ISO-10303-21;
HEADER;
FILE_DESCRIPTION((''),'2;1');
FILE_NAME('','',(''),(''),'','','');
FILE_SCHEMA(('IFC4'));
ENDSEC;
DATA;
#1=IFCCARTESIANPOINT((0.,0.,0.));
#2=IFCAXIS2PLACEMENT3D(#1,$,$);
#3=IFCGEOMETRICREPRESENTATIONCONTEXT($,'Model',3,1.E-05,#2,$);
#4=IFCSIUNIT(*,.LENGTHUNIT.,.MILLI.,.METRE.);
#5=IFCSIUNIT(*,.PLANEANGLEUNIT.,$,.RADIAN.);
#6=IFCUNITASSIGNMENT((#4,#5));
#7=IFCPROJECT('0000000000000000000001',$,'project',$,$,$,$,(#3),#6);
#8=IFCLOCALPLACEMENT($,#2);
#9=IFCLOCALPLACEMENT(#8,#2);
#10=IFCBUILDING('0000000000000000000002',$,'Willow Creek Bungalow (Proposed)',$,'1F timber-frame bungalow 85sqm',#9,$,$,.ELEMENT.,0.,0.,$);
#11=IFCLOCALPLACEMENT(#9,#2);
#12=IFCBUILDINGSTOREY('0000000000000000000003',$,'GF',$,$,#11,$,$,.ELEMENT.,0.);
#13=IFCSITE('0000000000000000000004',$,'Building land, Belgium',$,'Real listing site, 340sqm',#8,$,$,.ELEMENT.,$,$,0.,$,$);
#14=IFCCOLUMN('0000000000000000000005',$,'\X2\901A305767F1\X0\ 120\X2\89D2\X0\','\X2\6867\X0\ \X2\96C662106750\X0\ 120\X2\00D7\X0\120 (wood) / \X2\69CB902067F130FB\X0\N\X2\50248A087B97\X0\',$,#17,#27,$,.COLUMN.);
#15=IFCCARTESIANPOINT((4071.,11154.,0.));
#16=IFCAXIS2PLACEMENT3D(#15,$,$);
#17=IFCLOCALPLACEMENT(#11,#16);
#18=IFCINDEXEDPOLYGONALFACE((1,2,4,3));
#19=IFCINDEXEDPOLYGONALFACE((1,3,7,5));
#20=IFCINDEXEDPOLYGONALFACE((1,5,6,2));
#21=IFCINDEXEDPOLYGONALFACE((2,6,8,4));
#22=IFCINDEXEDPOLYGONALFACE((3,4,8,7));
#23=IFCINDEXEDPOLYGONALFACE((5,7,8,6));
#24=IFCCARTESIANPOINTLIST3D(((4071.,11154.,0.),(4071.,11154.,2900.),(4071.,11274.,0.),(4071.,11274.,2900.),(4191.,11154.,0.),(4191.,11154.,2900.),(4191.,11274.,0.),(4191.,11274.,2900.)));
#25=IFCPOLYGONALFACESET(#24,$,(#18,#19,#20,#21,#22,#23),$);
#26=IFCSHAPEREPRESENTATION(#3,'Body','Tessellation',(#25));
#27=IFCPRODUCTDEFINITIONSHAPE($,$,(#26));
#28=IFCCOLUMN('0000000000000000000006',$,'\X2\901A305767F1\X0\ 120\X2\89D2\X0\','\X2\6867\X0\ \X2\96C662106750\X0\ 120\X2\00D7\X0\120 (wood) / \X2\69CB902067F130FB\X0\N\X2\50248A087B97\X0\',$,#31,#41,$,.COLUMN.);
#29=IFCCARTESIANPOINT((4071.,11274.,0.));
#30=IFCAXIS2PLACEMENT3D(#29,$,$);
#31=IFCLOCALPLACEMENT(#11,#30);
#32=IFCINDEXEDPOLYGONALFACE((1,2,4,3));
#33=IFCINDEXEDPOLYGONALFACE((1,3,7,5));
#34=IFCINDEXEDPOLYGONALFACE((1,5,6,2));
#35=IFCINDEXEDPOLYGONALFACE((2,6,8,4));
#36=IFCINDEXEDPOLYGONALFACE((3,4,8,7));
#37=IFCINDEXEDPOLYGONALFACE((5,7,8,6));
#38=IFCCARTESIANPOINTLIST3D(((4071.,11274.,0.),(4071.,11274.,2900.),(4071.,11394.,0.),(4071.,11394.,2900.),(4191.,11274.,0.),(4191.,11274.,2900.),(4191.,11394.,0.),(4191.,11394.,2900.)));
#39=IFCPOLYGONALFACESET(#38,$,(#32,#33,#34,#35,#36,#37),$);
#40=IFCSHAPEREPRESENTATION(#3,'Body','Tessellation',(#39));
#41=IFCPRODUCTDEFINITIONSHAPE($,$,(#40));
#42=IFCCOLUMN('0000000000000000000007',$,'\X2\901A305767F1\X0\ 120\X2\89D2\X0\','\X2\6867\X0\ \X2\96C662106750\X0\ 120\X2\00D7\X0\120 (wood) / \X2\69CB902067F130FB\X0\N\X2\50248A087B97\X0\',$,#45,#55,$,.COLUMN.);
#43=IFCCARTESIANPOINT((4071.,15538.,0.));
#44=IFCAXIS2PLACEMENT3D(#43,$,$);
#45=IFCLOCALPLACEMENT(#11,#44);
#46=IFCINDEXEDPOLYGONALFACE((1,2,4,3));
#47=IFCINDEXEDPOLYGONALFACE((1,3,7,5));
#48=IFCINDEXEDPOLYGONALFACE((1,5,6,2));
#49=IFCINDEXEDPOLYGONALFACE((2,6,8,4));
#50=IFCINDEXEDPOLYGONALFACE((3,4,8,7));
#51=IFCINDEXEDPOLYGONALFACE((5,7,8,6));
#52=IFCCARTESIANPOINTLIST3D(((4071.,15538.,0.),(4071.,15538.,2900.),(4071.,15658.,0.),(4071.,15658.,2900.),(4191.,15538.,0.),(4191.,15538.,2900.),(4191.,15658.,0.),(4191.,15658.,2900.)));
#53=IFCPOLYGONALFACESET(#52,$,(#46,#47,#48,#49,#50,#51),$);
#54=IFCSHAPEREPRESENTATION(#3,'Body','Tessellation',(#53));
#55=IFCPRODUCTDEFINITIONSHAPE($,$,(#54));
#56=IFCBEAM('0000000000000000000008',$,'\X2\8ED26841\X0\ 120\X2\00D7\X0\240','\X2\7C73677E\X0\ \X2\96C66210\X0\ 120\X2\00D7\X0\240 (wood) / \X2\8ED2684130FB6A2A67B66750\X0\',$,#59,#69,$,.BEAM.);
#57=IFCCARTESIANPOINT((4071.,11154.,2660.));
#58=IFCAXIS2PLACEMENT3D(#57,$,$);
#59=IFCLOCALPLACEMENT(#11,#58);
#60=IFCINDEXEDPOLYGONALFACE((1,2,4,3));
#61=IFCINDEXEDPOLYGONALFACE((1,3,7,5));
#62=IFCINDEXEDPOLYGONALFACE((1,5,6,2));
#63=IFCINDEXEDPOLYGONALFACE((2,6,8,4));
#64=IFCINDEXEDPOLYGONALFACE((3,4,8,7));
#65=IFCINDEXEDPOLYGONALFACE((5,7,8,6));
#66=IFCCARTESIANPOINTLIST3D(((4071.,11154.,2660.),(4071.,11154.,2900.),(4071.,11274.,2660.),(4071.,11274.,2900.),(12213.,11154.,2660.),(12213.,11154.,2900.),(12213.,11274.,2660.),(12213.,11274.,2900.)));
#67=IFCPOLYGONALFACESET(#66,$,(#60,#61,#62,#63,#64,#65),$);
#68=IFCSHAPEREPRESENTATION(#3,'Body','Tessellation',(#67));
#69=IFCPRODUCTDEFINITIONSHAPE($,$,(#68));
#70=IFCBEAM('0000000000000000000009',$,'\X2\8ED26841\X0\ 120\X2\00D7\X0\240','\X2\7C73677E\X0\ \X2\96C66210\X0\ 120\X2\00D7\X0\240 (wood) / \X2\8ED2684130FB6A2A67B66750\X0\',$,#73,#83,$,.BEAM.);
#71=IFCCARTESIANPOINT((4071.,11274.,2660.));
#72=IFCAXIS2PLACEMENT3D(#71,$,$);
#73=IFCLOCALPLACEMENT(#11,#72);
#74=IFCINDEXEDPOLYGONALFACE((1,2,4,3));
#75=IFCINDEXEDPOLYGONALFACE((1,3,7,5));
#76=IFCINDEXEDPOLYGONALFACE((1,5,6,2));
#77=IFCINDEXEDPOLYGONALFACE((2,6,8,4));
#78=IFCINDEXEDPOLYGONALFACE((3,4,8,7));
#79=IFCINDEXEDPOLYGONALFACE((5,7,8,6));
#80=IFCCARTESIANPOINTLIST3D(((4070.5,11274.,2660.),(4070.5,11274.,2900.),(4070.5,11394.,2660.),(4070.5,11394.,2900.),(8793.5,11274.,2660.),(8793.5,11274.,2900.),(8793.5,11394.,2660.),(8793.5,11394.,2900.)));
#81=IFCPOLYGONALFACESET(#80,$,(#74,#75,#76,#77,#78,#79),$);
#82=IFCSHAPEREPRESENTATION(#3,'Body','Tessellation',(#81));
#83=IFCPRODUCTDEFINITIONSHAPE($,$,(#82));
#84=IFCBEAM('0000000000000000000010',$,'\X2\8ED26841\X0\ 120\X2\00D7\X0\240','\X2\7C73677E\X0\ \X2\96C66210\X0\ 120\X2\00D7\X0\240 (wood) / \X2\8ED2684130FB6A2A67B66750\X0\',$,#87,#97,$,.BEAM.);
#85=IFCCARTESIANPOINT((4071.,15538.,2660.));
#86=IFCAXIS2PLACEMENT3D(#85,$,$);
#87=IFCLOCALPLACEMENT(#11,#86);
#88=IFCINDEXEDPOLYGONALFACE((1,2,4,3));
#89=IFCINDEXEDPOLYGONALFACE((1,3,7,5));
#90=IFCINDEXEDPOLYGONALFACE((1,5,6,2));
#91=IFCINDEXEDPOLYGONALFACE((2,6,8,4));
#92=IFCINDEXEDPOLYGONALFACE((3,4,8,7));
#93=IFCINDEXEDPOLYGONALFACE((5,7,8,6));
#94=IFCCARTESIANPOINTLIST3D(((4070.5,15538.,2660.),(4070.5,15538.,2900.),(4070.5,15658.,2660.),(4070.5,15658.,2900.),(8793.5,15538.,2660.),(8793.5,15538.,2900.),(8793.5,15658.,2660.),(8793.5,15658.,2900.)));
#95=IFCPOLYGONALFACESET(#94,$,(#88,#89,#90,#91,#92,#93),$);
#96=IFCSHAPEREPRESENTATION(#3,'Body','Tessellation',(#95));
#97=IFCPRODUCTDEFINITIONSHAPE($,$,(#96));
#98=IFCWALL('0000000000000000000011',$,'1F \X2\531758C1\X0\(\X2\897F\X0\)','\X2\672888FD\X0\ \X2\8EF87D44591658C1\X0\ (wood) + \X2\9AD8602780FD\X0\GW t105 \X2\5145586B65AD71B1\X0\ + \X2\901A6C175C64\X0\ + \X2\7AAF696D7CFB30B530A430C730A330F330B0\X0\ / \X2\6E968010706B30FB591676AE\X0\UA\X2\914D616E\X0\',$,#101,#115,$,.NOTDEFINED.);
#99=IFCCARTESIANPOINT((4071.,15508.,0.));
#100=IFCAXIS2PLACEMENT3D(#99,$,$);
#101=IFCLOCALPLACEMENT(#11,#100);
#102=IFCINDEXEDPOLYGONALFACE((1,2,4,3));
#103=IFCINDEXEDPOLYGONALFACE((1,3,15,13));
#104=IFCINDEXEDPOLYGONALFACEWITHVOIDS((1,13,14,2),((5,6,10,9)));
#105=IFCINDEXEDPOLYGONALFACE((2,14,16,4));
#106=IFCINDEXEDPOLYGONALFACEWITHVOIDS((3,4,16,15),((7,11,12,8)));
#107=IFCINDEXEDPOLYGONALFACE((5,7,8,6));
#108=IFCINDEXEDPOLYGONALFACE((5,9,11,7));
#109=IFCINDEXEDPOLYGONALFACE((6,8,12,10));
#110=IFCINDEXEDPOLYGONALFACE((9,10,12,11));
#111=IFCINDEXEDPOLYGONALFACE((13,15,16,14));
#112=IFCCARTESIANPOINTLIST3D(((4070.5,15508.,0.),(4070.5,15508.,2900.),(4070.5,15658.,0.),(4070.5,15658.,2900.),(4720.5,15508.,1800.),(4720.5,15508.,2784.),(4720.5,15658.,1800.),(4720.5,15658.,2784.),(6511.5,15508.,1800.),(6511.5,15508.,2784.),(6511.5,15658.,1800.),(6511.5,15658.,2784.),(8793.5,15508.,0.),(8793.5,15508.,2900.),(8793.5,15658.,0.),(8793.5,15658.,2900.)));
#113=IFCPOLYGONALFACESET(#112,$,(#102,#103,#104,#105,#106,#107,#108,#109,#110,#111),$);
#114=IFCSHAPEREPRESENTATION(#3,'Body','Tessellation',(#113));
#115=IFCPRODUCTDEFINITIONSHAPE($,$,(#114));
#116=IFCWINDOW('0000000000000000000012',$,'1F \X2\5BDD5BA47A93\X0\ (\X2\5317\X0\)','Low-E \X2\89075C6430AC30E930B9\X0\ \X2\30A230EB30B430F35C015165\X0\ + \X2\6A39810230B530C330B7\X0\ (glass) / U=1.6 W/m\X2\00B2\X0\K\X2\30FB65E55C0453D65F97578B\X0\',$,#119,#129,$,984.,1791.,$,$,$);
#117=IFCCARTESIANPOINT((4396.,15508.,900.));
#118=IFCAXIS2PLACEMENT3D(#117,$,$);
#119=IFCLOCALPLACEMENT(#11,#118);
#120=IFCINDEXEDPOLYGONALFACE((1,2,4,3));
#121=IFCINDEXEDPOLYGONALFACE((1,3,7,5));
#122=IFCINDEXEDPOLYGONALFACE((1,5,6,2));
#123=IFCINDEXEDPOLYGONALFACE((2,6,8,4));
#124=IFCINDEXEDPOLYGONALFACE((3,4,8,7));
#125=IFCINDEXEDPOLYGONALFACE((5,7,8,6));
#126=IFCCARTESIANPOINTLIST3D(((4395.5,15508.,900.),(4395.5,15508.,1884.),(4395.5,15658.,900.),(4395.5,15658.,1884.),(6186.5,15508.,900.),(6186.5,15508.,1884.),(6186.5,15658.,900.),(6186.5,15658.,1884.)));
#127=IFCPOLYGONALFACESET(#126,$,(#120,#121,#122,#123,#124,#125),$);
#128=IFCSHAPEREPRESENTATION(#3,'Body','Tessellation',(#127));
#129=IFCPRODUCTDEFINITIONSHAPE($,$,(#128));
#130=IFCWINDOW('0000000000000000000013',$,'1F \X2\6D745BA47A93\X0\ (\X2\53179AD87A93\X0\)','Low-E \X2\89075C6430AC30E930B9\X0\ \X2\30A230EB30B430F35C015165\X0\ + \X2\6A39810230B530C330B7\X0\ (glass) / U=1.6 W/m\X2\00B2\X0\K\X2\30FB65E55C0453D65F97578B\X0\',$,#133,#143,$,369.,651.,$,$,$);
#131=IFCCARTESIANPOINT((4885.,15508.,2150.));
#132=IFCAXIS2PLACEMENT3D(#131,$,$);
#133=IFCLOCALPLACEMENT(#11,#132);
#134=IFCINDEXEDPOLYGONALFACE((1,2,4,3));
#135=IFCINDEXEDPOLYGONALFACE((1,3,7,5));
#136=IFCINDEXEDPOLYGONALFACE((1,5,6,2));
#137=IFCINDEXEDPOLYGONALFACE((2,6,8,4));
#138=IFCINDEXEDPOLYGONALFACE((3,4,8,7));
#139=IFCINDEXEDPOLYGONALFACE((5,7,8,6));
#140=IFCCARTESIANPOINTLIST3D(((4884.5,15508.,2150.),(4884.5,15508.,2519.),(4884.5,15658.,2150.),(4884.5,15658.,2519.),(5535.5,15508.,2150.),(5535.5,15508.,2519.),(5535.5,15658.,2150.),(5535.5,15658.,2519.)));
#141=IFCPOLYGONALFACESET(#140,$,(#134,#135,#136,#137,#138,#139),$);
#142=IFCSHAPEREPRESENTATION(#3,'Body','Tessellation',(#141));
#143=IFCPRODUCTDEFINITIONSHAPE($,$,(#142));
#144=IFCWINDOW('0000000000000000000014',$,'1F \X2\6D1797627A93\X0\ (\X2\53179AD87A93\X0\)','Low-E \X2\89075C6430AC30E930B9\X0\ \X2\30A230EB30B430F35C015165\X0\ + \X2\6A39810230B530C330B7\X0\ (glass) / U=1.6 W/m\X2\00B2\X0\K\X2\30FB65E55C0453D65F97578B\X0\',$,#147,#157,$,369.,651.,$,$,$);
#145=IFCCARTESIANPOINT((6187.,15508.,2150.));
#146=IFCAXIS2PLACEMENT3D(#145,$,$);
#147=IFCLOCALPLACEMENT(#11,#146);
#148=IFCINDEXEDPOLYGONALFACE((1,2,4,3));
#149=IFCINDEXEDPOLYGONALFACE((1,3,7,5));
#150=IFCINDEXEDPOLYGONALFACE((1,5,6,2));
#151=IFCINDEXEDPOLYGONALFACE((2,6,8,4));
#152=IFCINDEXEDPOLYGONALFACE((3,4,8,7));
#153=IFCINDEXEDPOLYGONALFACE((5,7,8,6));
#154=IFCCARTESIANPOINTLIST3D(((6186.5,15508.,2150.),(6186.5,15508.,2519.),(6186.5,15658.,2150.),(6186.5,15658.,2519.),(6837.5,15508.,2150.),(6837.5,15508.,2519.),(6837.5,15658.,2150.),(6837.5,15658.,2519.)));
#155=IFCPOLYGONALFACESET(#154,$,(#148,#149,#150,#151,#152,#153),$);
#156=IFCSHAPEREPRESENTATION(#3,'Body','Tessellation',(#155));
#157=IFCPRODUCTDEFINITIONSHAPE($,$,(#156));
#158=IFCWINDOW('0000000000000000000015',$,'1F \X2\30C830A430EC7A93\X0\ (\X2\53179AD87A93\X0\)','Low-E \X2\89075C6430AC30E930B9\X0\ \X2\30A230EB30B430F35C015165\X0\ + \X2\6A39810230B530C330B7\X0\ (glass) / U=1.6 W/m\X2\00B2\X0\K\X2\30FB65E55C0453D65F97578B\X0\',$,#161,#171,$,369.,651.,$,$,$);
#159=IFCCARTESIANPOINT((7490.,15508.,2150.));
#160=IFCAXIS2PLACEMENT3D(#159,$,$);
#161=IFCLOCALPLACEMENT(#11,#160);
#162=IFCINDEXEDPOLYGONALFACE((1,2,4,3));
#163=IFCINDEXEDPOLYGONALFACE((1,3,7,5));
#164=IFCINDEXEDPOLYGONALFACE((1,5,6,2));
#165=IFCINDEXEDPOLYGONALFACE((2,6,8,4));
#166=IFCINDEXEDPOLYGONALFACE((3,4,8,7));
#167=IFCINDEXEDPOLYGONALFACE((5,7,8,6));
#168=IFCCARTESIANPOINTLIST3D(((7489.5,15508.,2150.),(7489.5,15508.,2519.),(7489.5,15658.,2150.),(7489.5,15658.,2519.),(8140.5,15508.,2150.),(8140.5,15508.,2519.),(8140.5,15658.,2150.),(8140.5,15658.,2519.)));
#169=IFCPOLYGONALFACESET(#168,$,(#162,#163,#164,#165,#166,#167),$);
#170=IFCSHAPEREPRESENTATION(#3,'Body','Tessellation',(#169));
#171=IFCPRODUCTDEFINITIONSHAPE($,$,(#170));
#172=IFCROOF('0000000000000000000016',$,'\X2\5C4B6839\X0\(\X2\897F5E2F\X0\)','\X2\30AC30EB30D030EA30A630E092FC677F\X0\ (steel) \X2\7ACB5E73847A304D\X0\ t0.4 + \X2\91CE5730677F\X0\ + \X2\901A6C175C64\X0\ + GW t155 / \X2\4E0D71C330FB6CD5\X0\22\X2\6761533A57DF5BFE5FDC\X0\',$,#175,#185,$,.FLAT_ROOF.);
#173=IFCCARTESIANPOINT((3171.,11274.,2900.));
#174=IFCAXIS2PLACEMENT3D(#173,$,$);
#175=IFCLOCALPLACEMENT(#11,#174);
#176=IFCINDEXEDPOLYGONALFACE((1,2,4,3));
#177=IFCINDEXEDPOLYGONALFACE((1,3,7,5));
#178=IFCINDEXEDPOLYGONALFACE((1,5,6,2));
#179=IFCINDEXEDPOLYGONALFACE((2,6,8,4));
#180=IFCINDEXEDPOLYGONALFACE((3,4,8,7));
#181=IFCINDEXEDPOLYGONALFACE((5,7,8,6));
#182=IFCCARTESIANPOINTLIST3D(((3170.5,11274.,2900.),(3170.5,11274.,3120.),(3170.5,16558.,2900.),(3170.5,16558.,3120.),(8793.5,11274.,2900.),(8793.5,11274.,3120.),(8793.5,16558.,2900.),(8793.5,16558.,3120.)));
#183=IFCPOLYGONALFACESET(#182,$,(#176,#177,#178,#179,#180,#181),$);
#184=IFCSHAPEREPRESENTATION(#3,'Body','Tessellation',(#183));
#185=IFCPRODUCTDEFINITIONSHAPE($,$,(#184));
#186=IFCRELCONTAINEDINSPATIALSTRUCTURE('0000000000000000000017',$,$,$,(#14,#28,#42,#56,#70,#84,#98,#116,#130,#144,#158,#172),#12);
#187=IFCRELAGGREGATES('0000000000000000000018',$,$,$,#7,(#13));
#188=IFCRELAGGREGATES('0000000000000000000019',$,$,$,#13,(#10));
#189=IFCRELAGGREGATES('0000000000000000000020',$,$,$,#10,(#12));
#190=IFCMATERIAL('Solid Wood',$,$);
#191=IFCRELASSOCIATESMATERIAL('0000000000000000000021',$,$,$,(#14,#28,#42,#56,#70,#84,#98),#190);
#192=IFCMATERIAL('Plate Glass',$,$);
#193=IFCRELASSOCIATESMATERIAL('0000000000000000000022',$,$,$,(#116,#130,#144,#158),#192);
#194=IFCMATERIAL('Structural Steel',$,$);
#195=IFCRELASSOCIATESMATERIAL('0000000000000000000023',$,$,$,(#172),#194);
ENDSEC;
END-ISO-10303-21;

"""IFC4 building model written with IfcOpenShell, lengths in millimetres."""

from ifc_helpers import new_model, si_unit, frame, frame_2d, origin, place, context, project, spatial, rectangle, extrude, material, element, fill, save


model = new_model("IFC4")

# Units and contexts
model_context = context("Model", 3, precision=1e-05, world=origin())
ifc_project = project(units=[si_unit("LENGTHUNIT", "METRE", prefix="MILLI"), si_unit("PLANEANGLEUNIT", "RADIAN")], contexts=[model_context])

# Site, building, storey
site_placement = place(None, origin())
site = spatial("IfcSite", under=ifc_project, at=site_placement, Name="Building land, Belgium", ObjectType="Real listing site, 340sqm", CompositionType="ELEMENT", RefElevation=0.0)
building_placement = place(site_placement, origin())
building = spatial("IfcBuilding", under=site, at=building_placement, Name="Willow Creek Bungalow (Proposed)", ObjectType="1F timber-frame bungalow 85sqm", CompositionType="ELEMENT", ElevationOfRefHeight=0.0, ElevationOfTerrain=0.0)
storey_placement = place(building_placement, origin())
storey = spatial("IfcBuildingStorey", under=building, at=storey_placement, Name="GF", CompositionType="ELEMENT", Elevation=0.0)

# Columns
ifc_material_1 = material(Name="Solid Wood")
column_1_placement = place(storey_placement, frame((4071.0, 11154.0, 0.0)))
element("IfcColumn", 1, at=column_1_placement, inside=storey, material=ifc_material_1, Name="通し柱 120角", Description="桧 集成材 120×120 (wood) / 構造柱・N値計算", PredefinedType="COLUMN", context=model_context, shape_type="SweptSolid", body=[
    extrude(rectangle(XDim=120.0, YDim=120.0, at=frame_2d((60.0, 60.0))), frame((4071.0, 11154.0, 0.0)), (0.0, 0.0, 1.0), 2900.0),
])
column_2_placement = place(storey_placement, frame((4071.0, 11274.0, 0.0)))
element("IfcColumn", 2, at=column_2_placement, inside=storey, material=ifc_material_1, Name="通し柱 120角", Description="桧 集成材 120×120 (wood) / 構造柱・N値計算", PredefinedType="COLUMN", context=model_context, shape_type="SweptSolid", body=[
    extrude(rectangle(XDim=120.0, YDim=120.0, at=frame_2d((60.0, 60.0))), frame((4071.0, 11274.0, 0.0)), (0.0, 0.0, 1.0), 2900.0),
])
column_3_placement = place(storey_placement, frame((4071.0, 15538.0, 0.0)))
element("IfcColumn", 3, at=column_3_placement, inside=storey, material=ifc_material_1, Name="通し柱 120角", Description="桧 集成材 120×120 (wood) / 構造柱・N値計算", PredefinedType="COLUMN", context=model_context, shape_type="SweptSolid", body=[
    extrude(rectangle(XDim=120.0, YDim=120.0, at=frame_2d((60.0, 60.0))), frame((4071.0, 15538.0, 0.0)), (0.0, 0.0, 1.0), 2900.0),
])

# Beams
beam_1_placement = place(storey_placement, frame((4071.0, 11154.0, 2660.0)))
element("IfcBeam", 4, at=beam_1_placement, inside=storey, material=ifc_material_1, Name="軒桁 120×240", Description="米松 集成 120×240 (wood) / 軒桁・横架材", PredefinedType="BEAM", context=model_context, shape_type="SweptSolid", body=[
    extrude(rectangle(XDim=8142.0, YDim=120.0, at=frame_2d((4071.0, 60.0))), frame((4071.0, 11154.0, 2660.0)), (0.0, 0.0, 1.0), 240.0),
])
beam_2_placement = place(storey_placement, frame((4071.0, 11274.0, 2660.0)))
element("IfcBeam", 5, at=beam_2_placement, inside=storey, material=ifc_material_1, Name="軒桁 120×240", Description="米松 集成 120×240 (wood) / 軒桁・横架材", PredefinedType="BEAM", context=model_context, shape_type="SweptSolid", body=[
    extrude(rectangle(XDim=4723.0, YDim=120.0, at=frame_2d((2361.0, 60.0))), frame((4071.0, 11274.0, 2660.0)), (0.0, 0.0, 1.0), 240.0),
])
beam_3_placement = place(storey_placement, frame((4071.0, 15538.0, 2660.0)))
element("IfcBeam", 6, at=beam_3_placement, inside=storey, material=ifc_material_1, Name="軒桁 120×240", Description="米松 集成 120×240 (wood) / 軒桁・横架材", PredefinedType="BEAM", context=model_context, shape_type="SweptSolid", body=[
    extrude(rectangle(XDim=4723.0, YDim=120.0, at=frame_2d((2361.0, 60.0))), frame((4071.0, 15538.0, 2660.0)), (0.0, 0.0, 1.0), 240.0),
])

# Wall, openings, windows
wall_1_placement = place(storey_placement, frame((4071.0, 15508.0, 0.0)))
wall_1 = element("IfcWall", 7, at=wall_1_placement, inside=storey, material=ifc_material_1, Name="1F 北壁(西)", Description="木製 軸組外壁 (wood) + 高性能GW t105 充填断熱 + 通気層 + 窯業系サイディング / 準耐火・外皮UA配慮", PredefinedType="NOTDEFINED", context=model_context, shape_type="SweptSolid", body=[
    extrude(rectangle(XDim=4723.0, YDim=150.0, at=frame_2d((2361.0, 75.0))), frame((4071.0, 15508.0, 0.0)), (0.0, 0.0, 1.0), 2900.0),
])
opening_1_placement = place(storey_placement, frame((4396.0, 15508.0, 900.0)))
opening_1 = element("IfcOpeningElement", 8, at=opening_1_placement, cuts=wall_1, PredefinedType="NOTDEFINED", context=model_context, shape_type="SweptSolid", body=[
    extrude(rectangle(XDim=1791.0, YDim=150.0, at=frame_2d((895.0, 75.0))), frame((4396.0, 15508.0, 900.0)), (0.0, 0.0, 1.0), 984.0),
])
opening_2_placement = place(storey_placement, frame((4885.0, 15508.0, 2150.0)))
opening_2 = element("IfcOpeningElement", 9, at=opening_2_placement, cuts=wall_1, PredefinedType="NOTDEFINED", context=model_context, shape_type="SweptSolid", body=[
    extrude(rectangle(XDim=651.0, YDim=150.0, at=frame_2d((325.0, 75.0))), frame((4885.0, 15508.0, 2150.0)), (0.0, 0.0, 1.0), 369.0),
])
opening_3_placement = place(storey_placement, frame((6187.0, 15508.0, 2150.0)))
opening_3 = element("IfcOpeningElement", 10, at=opening_3_placement, cuts=wall_1, PredefinedType="NOTDEFINED", context=model_context, shape_type="SweptSolid", body=[
    extrude(rectangle(XDim=651.0, YDim=150.0, at=frame_2d((325.0, 75.0))), frame((6187.0, 15508.0, 2150.0)), (0.0, 0.0, 1.0), 369.0),
])
opening_4_placement = place(storey_placement, frame((7490.0, 15508.0, 2150.0)))
opening_4 = element("IfcOpeningElement", 11, at=opening_4_placement, cuts=wall_1, PredefinedType="NOTDEFINED", context=model_context, shape_type="SweptSolid", body=[
    extrude(rectangle(XDim=651.0, YDim=150.0, at=frame_2d((325.0, 75.0))), frame((7490.0, 15508.0, 2150.0)), (0.0, 0.0, 1.0), 369.0),
])
ifc_material_2 = material(Name="Plate Glass")
window_1_placement = place(storey_placement, frame((4396.0, 15508.0, 900.0)))
window_1 = element("IfcWindow", 12, at=window_1_placement, inside=storey, material=ifc_material_2, Name="1F 寝室窓 (北)", Description="Low-E 複層ガラス アルゴン封入 + 樹脂サッシ (glass) / U=1.6 W/m²K・日射取得型", OverallHeight=984.0, OverallWidth=1791.0, context=model_context, shape_type="SweptSolid", body=[
    extrude(rectangle(XDim=1791.0, YDim=150.0, at=frame_2d((895.0, 75.0))), frame((4396.0, 15508.0, 900.0)), (0.0, 0.0, 1.0), 984.0),
])
fill(opening_1, window_1)
window_2_placement = place(storey_placement, frame((4885.0, 15508.0, 2150.0)))
window_2 = element("IfcWindow", 13, at=window_2_placement, inside=storey, material=ifc_material_2, Name="1F 浴室窓 (北高窓)", Description="Low-E 複層ガラス アルゴン封入 + 樹脂サッシ (glass) / U=1.6 W/m²K・日射取得型", OverallHeight=369.0, OverallWidth=651.0, context=model_context, shape_type="SweptSolid", body=[
    extrude(rectangle(XDim=651.0, YDim=150.0, at=frame_2d((325.0, 75.0))), frame((4885.0, 15508.0, 2150.0)), (0.0, 0.0, 1.0), 369.0),
])
fill(opening_2, window_2)
window_3_placement = place(storey_placement, frame((6187.0, 15508.0, 2150.0)))
window_3 = element("IfcWindow", 14, at=window_3_placement, inside=storey, material=ifc_material_2, Name="1F 洗面窓 (北高窓)", Description="Low-E 複層ガラス アルゴン封入 + 樹脂サッシ (glass) / U=1.6 W/m²K・日射取得型", OverallHeight=369.0, OverallWidth=651.0, context=model_context, shape_type="SweptSolid", body=[
    extrude(rectangle(XDim=651.0, YDim=150.0, at=frame_2d((325.0, 75.0))), frame((6187.0, 15508.0, 2150.0)), (0.0, 0.0, 1.0), 369.0),
])
fill(opening_3, window_3)
window_4_placement = place(storey_placement, frame((7490.0, 15508.0, 2150.0)))
window_4 = element("IfcWindow", 15, at=window_4_placement, inside=storey, material=ifc_material_2, Name="1F トイレ窓 (北高窓)", Description="Low-E 複層ガラス アルゴン封入 + 樹脂サッシ (glass) / U=1.6 W/m²K・日射取得型", OverallHeight=369.0, OverallWidth=651.0, context=model_context, shape_type="SweptSolid", body=[
    extrude(rectangle(XDim=651.0, YDim=150.0, at=frame_2d((325.0, 75.0))), frame((7490.0, 15508.0, 2150.0)), (0.0, 0.0, 1.0), 369.0),
])
fill(opening_4, window_4)

# Roof
ifc_material_3 = material(Name="Structural Steel")
roof_placement = place(storey_placement, frame((3171.0, 11274.0, 2900.0)))
element("IfcRoof", 16, at=roof_placement, inside=storey, material=ifc_material_3, Name="屋根(西帯)", Description="ガルバリウム鋼板 (steel) 立平葺き t0.4 + 野地板 + 通気層 + GW t155 / 不燃・法22条区域対応", PredefinedType="FLAT_ROOF", context=model_context, shape_type="SweptSolid", body=[
    extrude(rectangle(XDim=5623.0, YDim=5284.0, at=frame_2d((2811.0, 2642.0))), frame((3171.0, 11274.0, 2900.0)), (0.0, 0.0, 1.0), 220.0),
])

save(model, "model.ifc")
